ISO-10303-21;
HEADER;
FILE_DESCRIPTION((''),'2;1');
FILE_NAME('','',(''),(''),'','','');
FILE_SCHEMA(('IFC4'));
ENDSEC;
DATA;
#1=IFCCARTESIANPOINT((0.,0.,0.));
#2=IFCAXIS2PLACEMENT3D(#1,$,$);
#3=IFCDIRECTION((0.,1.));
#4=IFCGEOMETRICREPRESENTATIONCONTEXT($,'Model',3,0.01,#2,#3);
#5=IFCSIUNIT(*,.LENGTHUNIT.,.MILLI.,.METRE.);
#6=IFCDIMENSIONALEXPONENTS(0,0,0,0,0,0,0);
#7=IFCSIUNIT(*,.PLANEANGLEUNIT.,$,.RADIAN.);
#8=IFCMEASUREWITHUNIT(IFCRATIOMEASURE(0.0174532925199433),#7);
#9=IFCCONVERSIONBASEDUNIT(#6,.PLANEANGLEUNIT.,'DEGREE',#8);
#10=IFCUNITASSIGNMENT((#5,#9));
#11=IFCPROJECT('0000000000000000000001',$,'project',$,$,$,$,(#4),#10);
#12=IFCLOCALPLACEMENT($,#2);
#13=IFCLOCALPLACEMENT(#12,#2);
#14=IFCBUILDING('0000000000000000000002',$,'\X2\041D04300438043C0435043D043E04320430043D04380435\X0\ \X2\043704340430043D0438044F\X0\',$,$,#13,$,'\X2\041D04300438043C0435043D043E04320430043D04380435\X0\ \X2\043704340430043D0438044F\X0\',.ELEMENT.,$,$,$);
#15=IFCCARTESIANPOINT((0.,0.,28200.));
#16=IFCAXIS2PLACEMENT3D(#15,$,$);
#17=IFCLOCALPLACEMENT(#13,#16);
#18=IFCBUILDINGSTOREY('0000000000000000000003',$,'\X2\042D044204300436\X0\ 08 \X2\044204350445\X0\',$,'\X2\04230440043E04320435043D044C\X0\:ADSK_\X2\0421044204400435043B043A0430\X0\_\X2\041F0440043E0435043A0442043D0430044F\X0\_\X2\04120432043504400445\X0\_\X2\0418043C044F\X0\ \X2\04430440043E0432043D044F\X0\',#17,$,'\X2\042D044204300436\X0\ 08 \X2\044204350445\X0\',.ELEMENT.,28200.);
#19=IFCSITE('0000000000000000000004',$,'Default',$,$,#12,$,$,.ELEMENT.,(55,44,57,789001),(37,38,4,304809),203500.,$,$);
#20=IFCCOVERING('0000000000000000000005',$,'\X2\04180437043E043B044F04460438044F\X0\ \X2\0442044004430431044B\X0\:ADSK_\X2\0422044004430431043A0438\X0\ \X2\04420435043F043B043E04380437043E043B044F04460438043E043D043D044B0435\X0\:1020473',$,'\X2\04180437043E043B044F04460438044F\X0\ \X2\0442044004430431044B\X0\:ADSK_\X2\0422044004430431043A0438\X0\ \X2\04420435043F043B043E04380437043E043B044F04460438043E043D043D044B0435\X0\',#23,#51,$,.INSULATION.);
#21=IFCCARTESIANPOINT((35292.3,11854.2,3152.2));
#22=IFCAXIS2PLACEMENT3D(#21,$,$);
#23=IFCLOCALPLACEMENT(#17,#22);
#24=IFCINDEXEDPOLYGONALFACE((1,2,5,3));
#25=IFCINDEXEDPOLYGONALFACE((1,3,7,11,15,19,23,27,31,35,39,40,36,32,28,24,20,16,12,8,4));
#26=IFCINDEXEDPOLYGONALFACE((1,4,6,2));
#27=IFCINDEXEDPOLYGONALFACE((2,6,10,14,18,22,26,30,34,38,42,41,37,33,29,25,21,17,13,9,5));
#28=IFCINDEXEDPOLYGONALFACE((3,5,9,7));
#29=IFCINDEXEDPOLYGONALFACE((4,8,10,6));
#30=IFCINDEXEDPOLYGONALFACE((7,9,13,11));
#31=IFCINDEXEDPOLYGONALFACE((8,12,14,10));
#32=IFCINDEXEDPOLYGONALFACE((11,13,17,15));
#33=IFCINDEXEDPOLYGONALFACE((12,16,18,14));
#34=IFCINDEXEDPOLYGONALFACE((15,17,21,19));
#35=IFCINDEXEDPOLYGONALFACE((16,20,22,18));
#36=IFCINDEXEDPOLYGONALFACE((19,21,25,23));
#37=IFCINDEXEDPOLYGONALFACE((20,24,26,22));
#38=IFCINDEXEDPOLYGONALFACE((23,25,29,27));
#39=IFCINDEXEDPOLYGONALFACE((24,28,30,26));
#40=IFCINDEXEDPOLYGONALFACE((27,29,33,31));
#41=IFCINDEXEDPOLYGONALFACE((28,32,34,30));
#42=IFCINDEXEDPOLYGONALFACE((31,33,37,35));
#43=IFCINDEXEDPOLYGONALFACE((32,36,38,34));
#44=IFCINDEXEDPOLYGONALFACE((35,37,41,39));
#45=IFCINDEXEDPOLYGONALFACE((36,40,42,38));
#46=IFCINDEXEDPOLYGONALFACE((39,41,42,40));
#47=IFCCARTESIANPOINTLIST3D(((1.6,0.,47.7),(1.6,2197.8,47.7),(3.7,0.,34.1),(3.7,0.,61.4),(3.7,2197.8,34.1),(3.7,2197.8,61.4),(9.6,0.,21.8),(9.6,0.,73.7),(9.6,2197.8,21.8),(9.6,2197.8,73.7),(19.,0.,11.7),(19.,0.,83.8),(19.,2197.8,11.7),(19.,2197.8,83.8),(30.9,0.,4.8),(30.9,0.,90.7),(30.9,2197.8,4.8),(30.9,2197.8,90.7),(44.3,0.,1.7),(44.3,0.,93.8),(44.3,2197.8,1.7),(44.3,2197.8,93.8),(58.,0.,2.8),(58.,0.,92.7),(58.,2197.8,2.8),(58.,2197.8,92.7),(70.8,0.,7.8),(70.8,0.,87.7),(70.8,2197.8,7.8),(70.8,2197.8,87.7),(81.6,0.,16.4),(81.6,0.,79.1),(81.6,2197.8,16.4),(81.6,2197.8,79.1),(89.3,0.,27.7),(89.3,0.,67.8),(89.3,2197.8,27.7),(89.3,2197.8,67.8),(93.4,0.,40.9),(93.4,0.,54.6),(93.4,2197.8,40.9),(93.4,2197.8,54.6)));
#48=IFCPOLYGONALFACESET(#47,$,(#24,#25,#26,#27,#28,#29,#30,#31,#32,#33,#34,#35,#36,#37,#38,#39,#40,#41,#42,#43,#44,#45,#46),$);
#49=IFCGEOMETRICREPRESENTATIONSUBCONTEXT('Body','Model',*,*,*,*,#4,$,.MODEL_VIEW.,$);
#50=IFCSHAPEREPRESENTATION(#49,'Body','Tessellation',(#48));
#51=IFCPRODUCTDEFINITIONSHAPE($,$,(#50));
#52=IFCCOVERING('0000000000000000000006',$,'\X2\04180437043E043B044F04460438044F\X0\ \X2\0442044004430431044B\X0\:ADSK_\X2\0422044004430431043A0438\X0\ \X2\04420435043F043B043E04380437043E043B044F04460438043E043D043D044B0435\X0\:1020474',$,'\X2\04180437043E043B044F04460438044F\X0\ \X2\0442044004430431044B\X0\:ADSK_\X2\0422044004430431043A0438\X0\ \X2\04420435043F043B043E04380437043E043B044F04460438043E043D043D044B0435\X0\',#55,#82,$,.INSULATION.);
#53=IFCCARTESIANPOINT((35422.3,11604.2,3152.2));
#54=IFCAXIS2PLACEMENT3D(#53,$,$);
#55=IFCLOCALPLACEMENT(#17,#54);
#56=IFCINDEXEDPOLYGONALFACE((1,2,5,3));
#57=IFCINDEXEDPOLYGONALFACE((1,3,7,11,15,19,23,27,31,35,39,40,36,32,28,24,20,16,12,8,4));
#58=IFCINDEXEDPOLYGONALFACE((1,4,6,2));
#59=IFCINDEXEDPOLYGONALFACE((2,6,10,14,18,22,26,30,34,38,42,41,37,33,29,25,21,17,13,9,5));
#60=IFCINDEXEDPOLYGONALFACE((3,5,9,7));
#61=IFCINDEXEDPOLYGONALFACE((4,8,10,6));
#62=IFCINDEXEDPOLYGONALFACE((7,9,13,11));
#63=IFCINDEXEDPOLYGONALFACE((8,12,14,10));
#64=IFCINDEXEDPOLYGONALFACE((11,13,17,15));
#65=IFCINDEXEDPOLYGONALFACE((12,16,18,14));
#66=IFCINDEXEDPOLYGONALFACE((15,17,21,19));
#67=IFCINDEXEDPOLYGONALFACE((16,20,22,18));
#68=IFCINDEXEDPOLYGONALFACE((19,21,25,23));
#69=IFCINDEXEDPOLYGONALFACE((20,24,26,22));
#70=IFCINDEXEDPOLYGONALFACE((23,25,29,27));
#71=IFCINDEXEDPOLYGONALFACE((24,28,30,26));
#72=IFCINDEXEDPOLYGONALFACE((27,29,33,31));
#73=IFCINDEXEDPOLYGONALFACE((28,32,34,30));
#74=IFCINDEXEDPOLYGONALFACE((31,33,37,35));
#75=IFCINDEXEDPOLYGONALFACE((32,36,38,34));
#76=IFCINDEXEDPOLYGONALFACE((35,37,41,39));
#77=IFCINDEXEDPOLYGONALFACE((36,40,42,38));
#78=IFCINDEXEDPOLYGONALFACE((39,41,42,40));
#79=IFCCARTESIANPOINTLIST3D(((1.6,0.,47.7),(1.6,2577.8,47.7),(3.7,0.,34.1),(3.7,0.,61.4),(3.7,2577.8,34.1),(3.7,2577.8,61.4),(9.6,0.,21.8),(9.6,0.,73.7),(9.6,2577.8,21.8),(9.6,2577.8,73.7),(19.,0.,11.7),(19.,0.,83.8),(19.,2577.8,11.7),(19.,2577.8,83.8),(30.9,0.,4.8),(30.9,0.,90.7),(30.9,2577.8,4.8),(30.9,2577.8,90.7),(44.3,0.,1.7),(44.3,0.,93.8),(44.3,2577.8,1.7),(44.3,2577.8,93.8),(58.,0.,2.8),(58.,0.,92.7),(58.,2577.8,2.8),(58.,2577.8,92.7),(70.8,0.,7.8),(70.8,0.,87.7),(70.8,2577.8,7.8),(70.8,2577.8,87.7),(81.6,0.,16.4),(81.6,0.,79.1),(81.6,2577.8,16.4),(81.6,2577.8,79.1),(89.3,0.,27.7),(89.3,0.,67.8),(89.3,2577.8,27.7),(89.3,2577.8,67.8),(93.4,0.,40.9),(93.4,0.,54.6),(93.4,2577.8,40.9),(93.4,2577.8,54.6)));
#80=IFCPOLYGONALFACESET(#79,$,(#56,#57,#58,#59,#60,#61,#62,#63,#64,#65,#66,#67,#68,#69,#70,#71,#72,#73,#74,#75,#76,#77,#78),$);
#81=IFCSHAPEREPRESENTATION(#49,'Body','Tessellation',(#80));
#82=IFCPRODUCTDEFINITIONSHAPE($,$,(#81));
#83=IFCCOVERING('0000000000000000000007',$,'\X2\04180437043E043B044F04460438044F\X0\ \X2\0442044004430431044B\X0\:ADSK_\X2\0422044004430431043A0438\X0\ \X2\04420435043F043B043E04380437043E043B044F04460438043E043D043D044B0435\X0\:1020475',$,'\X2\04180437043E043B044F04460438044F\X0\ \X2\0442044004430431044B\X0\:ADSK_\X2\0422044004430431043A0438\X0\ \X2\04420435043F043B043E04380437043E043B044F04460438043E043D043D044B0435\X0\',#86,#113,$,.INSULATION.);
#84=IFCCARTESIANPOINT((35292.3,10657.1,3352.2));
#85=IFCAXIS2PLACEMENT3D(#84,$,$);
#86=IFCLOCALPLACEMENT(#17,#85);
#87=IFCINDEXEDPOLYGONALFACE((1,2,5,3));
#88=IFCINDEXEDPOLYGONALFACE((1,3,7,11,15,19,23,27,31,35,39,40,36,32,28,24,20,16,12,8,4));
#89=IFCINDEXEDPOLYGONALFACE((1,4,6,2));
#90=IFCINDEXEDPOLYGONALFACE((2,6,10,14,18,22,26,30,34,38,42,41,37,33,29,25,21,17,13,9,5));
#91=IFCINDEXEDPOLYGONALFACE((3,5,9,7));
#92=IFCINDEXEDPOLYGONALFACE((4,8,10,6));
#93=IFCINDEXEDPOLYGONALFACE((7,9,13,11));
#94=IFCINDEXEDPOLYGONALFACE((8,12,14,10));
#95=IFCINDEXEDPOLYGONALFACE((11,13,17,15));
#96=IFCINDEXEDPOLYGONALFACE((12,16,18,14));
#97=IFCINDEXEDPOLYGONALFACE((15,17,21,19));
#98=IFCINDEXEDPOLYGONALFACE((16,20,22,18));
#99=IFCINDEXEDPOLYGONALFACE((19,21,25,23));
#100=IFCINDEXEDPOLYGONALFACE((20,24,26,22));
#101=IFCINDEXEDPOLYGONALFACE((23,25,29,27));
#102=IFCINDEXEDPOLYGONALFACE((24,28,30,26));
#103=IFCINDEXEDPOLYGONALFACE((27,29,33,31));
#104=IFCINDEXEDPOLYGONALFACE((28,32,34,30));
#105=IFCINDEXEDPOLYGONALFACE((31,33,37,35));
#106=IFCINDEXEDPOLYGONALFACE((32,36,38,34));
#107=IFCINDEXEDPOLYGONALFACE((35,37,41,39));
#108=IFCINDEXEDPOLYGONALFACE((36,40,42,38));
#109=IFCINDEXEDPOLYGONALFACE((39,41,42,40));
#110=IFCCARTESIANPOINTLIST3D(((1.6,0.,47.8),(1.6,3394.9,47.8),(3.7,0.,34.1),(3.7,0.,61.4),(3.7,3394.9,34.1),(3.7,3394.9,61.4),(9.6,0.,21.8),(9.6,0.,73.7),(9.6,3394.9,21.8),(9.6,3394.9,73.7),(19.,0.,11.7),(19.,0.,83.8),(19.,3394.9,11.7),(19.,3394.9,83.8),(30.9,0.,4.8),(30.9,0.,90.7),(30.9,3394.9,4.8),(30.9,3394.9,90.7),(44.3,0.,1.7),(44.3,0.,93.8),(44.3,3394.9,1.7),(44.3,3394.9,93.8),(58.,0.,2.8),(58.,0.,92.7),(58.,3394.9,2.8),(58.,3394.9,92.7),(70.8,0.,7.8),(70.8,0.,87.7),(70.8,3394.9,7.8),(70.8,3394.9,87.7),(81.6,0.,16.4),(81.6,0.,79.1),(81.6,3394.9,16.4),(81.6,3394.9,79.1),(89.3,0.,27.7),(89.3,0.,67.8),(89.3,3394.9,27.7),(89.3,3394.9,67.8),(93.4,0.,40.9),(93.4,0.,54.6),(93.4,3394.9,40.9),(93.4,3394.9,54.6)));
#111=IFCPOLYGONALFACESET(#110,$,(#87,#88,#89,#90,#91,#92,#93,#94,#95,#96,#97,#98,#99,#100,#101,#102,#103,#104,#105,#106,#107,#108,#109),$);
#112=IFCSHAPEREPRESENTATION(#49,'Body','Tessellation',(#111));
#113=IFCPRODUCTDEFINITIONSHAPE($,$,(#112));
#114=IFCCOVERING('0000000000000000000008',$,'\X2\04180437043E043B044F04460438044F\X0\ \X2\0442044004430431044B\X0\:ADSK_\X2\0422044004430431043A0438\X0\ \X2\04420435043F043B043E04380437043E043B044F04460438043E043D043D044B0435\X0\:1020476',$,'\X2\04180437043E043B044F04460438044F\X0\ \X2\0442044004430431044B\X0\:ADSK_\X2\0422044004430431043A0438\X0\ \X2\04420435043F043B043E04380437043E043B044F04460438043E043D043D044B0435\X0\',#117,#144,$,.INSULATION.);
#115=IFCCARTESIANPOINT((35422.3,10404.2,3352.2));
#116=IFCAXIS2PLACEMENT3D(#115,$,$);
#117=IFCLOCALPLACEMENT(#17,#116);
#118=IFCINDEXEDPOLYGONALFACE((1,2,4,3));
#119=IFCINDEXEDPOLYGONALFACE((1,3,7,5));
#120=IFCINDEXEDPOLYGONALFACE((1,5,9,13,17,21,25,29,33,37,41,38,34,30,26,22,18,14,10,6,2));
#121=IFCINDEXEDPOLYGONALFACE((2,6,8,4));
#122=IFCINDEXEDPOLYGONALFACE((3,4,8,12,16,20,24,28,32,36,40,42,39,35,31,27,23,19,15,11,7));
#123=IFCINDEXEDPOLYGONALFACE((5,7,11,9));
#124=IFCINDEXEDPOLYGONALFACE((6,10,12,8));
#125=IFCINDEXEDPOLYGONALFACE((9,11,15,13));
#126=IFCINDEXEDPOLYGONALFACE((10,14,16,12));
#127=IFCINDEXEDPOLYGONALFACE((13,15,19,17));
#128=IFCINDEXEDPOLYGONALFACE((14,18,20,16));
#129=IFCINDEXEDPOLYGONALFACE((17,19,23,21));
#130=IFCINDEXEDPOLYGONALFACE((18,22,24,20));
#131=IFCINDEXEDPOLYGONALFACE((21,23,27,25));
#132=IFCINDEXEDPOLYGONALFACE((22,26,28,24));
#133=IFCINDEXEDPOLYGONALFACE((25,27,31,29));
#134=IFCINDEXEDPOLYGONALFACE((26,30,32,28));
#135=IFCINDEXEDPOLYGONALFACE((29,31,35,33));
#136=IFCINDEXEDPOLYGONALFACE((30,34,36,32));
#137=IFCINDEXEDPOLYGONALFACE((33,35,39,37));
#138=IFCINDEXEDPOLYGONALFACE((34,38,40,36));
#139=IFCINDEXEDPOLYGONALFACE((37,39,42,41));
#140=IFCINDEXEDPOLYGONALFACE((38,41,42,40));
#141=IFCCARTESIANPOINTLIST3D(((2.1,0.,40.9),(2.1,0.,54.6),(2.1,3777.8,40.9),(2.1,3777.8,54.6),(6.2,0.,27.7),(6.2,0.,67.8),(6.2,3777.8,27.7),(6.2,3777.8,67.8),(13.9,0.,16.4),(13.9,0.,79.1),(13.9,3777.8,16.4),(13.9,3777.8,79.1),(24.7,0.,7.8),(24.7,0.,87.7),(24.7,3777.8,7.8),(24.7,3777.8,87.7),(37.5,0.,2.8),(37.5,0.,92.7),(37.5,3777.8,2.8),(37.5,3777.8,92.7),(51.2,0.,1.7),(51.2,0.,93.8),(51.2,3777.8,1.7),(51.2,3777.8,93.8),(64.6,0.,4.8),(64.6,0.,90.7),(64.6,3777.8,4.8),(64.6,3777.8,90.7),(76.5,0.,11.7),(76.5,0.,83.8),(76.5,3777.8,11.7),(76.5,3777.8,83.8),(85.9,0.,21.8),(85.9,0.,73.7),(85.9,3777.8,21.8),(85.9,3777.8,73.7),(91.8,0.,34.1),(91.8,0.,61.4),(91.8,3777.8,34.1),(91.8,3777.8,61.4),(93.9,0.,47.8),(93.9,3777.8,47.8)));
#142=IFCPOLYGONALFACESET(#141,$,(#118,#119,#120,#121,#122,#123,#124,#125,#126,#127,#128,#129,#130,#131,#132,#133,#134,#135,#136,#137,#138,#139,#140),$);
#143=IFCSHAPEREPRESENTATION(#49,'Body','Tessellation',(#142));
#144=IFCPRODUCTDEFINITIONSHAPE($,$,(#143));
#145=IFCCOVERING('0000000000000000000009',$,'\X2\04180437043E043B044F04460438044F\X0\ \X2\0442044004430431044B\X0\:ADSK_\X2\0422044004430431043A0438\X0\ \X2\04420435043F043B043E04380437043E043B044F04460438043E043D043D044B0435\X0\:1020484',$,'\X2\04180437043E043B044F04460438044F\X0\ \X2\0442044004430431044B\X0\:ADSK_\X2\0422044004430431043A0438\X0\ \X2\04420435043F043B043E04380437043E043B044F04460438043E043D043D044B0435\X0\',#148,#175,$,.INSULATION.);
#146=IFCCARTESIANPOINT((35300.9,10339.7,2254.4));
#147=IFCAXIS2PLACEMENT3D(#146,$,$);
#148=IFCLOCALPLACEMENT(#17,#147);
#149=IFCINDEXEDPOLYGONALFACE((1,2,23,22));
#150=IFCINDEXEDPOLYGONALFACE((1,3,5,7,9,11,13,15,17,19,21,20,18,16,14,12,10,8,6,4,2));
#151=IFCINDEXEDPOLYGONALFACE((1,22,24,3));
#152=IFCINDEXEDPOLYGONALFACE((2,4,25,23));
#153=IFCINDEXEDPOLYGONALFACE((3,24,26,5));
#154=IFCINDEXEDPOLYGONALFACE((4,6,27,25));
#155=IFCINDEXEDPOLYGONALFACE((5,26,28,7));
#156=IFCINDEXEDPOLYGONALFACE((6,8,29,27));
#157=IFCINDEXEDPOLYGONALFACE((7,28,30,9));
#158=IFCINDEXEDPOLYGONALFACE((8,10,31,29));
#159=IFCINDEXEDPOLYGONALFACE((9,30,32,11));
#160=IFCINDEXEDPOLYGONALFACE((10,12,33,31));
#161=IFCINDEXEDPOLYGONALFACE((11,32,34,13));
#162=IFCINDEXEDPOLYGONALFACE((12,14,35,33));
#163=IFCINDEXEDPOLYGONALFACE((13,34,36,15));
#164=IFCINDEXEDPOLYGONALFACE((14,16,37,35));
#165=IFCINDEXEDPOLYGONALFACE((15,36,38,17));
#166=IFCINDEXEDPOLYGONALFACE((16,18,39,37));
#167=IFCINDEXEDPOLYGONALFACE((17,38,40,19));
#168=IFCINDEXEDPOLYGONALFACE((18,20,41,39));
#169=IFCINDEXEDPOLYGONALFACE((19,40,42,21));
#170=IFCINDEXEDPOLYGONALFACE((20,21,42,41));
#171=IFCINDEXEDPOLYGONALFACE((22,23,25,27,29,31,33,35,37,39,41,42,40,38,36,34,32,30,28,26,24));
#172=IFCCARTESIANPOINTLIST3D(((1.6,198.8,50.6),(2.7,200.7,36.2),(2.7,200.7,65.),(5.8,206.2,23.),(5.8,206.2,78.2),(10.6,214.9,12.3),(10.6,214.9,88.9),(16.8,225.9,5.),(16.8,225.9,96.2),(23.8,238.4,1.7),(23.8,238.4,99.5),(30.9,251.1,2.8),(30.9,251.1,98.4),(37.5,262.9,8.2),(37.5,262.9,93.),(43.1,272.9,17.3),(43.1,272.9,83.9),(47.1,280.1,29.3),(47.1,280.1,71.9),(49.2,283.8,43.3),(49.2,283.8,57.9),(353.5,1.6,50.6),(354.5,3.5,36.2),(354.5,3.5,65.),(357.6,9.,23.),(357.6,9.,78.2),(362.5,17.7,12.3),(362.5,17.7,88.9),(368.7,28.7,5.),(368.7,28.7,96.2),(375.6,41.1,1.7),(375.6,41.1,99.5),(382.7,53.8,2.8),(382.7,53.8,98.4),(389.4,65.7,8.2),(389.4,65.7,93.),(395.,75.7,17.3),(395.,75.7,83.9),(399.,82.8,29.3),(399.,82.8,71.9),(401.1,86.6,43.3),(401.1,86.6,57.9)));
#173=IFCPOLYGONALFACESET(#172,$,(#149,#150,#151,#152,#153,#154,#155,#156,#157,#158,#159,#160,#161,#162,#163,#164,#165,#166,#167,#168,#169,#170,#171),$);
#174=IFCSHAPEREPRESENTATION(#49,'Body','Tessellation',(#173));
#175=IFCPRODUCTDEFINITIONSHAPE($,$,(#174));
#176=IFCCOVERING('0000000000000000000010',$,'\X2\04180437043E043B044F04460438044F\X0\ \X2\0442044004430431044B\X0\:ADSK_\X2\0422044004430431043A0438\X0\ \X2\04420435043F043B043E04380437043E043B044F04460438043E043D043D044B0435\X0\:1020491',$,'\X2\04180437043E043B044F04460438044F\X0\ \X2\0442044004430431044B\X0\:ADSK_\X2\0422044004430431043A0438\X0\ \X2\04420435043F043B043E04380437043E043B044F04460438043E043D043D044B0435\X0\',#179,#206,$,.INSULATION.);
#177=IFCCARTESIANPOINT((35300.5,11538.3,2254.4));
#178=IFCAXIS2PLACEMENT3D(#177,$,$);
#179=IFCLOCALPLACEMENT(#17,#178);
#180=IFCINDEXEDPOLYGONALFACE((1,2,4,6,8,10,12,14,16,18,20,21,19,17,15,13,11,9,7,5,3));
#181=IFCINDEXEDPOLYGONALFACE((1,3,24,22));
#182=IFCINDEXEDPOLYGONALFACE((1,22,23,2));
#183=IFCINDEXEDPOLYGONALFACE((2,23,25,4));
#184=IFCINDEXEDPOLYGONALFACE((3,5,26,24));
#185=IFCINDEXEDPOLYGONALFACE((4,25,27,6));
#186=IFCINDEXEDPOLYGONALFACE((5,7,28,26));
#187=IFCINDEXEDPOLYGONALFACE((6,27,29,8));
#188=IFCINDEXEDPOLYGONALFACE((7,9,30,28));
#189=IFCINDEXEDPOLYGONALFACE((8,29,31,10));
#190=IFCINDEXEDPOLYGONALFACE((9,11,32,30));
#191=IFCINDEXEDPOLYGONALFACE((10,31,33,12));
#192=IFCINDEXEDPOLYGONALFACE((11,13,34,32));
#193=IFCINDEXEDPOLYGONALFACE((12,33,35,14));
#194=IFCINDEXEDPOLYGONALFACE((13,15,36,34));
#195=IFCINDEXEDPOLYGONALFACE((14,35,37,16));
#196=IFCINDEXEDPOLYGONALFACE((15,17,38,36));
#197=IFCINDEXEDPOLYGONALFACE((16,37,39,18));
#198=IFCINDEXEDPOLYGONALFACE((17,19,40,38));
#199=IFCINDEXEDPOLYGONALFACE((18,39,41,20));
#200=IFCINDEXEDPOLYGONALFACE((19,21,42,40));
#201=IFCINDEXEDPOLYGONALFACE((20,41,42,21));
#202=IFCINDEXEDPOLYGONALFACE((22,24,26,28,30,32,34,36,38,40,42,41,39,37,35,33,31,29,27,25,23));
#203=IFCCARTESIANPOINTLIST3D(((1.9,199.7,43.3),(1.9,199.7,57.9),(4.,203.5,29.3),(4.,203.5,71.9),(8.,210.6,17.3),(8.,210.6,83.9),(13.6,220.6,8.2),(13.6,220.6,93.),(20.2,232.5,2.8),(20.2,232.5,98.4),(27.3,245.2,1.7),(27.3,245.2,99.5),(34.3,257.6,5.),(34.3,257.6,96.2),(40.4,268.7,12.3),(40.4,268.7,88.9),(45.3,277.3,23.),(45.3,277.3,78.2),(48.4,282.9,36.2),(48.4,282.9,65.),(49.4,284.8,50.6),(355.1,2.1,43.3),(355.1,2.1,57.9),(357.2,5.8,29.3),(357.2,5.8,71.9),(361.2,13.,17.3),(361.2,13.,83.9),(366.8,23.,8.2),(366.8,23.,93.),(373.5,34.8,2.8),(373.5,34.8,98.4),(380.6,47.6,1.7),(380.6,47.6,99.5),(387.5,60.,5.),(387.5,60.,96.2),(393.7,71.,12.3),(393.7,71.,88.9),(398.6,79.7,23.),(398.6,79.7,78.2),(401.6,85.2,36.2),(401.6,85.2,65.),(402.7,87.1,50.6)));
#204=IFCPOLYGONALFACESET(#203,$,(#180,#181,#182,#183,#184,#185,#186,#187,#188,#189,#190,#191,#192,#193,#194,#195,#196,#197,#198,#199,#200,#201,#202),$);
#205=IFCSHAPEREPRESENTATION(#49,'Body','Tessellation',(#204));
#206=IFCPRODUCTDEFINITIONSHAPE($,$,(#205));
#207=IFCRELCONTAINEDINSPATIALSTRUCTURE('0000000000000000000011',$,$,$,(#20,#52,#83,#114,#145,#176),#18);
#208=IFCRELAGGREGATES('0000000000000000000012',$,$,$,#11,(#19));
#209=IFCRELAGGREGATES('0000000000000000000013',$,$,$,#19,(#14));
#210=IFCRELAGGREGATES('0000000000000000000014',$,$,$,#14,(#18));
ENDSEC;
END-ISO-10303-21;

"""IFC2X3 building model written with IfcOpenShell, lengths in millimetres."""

from ifc_helpers import new_model, entity, si_unit, converted_unit, direction, frame, origin, origin_2d_with_axis, place, context, subcontext, project, spatial, circle, extrude, element, save


model = new_model("IFC2X3")

# Units and contexts
model_context = context("Model", 3, precision=0.01, world=origin(), true_north=direction((0.0, 1.0)))
body_context = subcontext(model_context, "Body", "Model", "MODEL_VIEW")
ifc_project = project(units=[si_unit("LENGTHUNIT", "METRE", prefix="MILLI"), converted_unit("PLANEANGLEUNIT", "DEGREE", entity("IfcRatioMeasure", 0.0174532925199433), si_unit("PLANEANGLEUNIT", "RADIAN"), dimensions=[0, 0, 0, 0, 0, 0, 0])], contexts=[model_context])

# Site, building, storey
site_placement = place(None, origin())
site = spatial("IfcSite", under=ifc_project, at=site_placement, Name="Default", CompositionType="ELEMENT", RefLatitude=(55, 44, 57, 789001), RefLongitude=(37, 38, 4, 304809), RefElevation=203500.0)
building_placement = place(site_placement, origin())
building = spatial("IfcBuilding", under=site, at=building_placement, Name="Наименование здания", LongName="Наименование здания", CompositionType="ELEMENT")
storey_placement = place(building_placement, frame((0.0, 0.0, 28200.0)))
storey = spatial("IfcBuildingStorey", under=building, at=storey_placement, Name="Этаж 08 тех", ObjectType="Уровень:ADSK_Стрелка_Проектная_Вверх_Имя уровня", LongName="Этаж 08 тех", CompositionType="ELEMENT", Elevation=28200.0)

# Coverings
covering_1_placement = place(storey_placement, frame((35292.3, 11854.2, 3152.2)))
element("IfcCovering", 1, at=covering_1_placement, inside=storey, Name="Изоляция трубы:ADSK_Трубки теплоизоляционные:1020473", ObjectType="Изоляция трубы:ADSK_Трубки теплоизоляционные", PredefinedType="INSULATION", context=body_context, shape_type="SweptSolid", body=[
    extrude(circle(Radius=46.1, at=origin_2d_with_axis()), frame((47.8, 0.0, 47.8), z_axis=(0.0, 1.0, 0.0), x_axis=(-1.0, 0.0, 0.0)), (0.0, 0.0, 1.0), 2197.8),
])
covering_2_placement = place(storey_placement, frame((35422.3, 11604.2, 3152.2)))
element("IfcCovering", 2, at=covering_2_placement, inside=storey, Name="Изоляция трубы:ADSK_Трубки теплоизоляционные:1020474", ObjectType="Изоляция трубы:ADSK_Трубки теплоизоляционные", PredefinedType="INSULATION", context=body_context, shape_type="SweptSolid", body=[
    extrude(circle(Radius=46.1, at=origin_2d_with_axis()), frame((47.8, 0.0, 47.8), z_axis=(0.0, 1.0, 0.0), x_axis=(-1.0, 0.0, 0.0)), (0.0, 0.0, 1.0), 2577.8),
])
covering_3_placement = place(storey_placement, frame((35292.3, 10657.1, 3352.2)))
element("IfcCovering", 3, at=covering_3_placement, inside=storey, Name="Изоляция трубы:ADSK_Трубки теплоизоляционные:1020475", ObjectType="Изоляция трубы:ADSK_Трубки теплоизоляционные", PredefinedType="INSULATION", context=body_context, shape_type="SweptSolid", body=[
    extrude(circle(Radius=46.1, at=origin_2d_with_axis()), frame((47.8, 0.0, 47.8), z_axis=(0.0, 1.0, 0.0), x_axis=(-1.0, 0.0, 0.0)), (0.0, 0.0, 1.0), 3394.9),
])
covering_4_placement = place(storey_placement, frame((35422.3, 10404.2, 3352.2)))
element("IfcCovering", 4, at=covering_4_placement, inside=storey, Name="Изоляция трубы:ADSK_Трубки теплоизоляционные:1020476", ObjectType="Изоляция трубы:ADSK_Трубки теплоизоляционные", PredefinedType="INSULATION", context=body_context, shape_type="SweptSolid", body=[
    extrude(circle(Radius=46.1, at=origin_2d_with_axis()), frame((47.8, 0.0, 47.8), z_axis=(0.0, 1.0, 0.0), x_axis=(1.0, 0.0, 0.0)), (0.0, 0.0, 1.0), 3777.8),
])
covering_5_placement = place(storey_placement, frame((35300.9, 10339.7, 2254.4)))
element("IfcCovering", 5, at=covering_5_placement, inside=storey, Name="Изоляция трубы:ADSK_Трубки теплоизоляционные:1020484", ObjectType="Изоляция трубы:ADSK_Трубки теплоизоляционные", PredefinedType="INSULATION", context=body_context, shape_type="SweptSolid", body=[
    extrude(circle(Radius=49.0, at=origin_2d_with_axis()), frame((25.6, 241.6, 50.6), z_axis=(0.872329, -0.48892, 0.0), x_axis=(-0.48892, -0.872329, 0.0)), (0.0, 0.0, 1.0), 403.4),
])
covering_6_placement = place(storey_placement, frame((35300.5, 11538.3, 2254.4)))
element("IfcCovering", 6, at=covering_6_placement, inside=storey, Name="Изоляция трубы:ADSK_Трубки теплоизоляционные:1020491", ObjectType="Изоляция трубы:ADSK_Трубки теплоизоляционные", PredefinedType="INSULATION", context=body_context, shape_type="SweptSolid", body=[
    extrude(circle(Radius=49.0, at=origin_2d_with_axis()), frame((25.5, 242.0, 50.6), z_axis=(0.87271, -0.488239, 0.0), x_axis=(0.488239, 0.87271, 0.0)), (0.0, 0.0, 1.0), 404.8),
])

save(model, "model.ifc")
